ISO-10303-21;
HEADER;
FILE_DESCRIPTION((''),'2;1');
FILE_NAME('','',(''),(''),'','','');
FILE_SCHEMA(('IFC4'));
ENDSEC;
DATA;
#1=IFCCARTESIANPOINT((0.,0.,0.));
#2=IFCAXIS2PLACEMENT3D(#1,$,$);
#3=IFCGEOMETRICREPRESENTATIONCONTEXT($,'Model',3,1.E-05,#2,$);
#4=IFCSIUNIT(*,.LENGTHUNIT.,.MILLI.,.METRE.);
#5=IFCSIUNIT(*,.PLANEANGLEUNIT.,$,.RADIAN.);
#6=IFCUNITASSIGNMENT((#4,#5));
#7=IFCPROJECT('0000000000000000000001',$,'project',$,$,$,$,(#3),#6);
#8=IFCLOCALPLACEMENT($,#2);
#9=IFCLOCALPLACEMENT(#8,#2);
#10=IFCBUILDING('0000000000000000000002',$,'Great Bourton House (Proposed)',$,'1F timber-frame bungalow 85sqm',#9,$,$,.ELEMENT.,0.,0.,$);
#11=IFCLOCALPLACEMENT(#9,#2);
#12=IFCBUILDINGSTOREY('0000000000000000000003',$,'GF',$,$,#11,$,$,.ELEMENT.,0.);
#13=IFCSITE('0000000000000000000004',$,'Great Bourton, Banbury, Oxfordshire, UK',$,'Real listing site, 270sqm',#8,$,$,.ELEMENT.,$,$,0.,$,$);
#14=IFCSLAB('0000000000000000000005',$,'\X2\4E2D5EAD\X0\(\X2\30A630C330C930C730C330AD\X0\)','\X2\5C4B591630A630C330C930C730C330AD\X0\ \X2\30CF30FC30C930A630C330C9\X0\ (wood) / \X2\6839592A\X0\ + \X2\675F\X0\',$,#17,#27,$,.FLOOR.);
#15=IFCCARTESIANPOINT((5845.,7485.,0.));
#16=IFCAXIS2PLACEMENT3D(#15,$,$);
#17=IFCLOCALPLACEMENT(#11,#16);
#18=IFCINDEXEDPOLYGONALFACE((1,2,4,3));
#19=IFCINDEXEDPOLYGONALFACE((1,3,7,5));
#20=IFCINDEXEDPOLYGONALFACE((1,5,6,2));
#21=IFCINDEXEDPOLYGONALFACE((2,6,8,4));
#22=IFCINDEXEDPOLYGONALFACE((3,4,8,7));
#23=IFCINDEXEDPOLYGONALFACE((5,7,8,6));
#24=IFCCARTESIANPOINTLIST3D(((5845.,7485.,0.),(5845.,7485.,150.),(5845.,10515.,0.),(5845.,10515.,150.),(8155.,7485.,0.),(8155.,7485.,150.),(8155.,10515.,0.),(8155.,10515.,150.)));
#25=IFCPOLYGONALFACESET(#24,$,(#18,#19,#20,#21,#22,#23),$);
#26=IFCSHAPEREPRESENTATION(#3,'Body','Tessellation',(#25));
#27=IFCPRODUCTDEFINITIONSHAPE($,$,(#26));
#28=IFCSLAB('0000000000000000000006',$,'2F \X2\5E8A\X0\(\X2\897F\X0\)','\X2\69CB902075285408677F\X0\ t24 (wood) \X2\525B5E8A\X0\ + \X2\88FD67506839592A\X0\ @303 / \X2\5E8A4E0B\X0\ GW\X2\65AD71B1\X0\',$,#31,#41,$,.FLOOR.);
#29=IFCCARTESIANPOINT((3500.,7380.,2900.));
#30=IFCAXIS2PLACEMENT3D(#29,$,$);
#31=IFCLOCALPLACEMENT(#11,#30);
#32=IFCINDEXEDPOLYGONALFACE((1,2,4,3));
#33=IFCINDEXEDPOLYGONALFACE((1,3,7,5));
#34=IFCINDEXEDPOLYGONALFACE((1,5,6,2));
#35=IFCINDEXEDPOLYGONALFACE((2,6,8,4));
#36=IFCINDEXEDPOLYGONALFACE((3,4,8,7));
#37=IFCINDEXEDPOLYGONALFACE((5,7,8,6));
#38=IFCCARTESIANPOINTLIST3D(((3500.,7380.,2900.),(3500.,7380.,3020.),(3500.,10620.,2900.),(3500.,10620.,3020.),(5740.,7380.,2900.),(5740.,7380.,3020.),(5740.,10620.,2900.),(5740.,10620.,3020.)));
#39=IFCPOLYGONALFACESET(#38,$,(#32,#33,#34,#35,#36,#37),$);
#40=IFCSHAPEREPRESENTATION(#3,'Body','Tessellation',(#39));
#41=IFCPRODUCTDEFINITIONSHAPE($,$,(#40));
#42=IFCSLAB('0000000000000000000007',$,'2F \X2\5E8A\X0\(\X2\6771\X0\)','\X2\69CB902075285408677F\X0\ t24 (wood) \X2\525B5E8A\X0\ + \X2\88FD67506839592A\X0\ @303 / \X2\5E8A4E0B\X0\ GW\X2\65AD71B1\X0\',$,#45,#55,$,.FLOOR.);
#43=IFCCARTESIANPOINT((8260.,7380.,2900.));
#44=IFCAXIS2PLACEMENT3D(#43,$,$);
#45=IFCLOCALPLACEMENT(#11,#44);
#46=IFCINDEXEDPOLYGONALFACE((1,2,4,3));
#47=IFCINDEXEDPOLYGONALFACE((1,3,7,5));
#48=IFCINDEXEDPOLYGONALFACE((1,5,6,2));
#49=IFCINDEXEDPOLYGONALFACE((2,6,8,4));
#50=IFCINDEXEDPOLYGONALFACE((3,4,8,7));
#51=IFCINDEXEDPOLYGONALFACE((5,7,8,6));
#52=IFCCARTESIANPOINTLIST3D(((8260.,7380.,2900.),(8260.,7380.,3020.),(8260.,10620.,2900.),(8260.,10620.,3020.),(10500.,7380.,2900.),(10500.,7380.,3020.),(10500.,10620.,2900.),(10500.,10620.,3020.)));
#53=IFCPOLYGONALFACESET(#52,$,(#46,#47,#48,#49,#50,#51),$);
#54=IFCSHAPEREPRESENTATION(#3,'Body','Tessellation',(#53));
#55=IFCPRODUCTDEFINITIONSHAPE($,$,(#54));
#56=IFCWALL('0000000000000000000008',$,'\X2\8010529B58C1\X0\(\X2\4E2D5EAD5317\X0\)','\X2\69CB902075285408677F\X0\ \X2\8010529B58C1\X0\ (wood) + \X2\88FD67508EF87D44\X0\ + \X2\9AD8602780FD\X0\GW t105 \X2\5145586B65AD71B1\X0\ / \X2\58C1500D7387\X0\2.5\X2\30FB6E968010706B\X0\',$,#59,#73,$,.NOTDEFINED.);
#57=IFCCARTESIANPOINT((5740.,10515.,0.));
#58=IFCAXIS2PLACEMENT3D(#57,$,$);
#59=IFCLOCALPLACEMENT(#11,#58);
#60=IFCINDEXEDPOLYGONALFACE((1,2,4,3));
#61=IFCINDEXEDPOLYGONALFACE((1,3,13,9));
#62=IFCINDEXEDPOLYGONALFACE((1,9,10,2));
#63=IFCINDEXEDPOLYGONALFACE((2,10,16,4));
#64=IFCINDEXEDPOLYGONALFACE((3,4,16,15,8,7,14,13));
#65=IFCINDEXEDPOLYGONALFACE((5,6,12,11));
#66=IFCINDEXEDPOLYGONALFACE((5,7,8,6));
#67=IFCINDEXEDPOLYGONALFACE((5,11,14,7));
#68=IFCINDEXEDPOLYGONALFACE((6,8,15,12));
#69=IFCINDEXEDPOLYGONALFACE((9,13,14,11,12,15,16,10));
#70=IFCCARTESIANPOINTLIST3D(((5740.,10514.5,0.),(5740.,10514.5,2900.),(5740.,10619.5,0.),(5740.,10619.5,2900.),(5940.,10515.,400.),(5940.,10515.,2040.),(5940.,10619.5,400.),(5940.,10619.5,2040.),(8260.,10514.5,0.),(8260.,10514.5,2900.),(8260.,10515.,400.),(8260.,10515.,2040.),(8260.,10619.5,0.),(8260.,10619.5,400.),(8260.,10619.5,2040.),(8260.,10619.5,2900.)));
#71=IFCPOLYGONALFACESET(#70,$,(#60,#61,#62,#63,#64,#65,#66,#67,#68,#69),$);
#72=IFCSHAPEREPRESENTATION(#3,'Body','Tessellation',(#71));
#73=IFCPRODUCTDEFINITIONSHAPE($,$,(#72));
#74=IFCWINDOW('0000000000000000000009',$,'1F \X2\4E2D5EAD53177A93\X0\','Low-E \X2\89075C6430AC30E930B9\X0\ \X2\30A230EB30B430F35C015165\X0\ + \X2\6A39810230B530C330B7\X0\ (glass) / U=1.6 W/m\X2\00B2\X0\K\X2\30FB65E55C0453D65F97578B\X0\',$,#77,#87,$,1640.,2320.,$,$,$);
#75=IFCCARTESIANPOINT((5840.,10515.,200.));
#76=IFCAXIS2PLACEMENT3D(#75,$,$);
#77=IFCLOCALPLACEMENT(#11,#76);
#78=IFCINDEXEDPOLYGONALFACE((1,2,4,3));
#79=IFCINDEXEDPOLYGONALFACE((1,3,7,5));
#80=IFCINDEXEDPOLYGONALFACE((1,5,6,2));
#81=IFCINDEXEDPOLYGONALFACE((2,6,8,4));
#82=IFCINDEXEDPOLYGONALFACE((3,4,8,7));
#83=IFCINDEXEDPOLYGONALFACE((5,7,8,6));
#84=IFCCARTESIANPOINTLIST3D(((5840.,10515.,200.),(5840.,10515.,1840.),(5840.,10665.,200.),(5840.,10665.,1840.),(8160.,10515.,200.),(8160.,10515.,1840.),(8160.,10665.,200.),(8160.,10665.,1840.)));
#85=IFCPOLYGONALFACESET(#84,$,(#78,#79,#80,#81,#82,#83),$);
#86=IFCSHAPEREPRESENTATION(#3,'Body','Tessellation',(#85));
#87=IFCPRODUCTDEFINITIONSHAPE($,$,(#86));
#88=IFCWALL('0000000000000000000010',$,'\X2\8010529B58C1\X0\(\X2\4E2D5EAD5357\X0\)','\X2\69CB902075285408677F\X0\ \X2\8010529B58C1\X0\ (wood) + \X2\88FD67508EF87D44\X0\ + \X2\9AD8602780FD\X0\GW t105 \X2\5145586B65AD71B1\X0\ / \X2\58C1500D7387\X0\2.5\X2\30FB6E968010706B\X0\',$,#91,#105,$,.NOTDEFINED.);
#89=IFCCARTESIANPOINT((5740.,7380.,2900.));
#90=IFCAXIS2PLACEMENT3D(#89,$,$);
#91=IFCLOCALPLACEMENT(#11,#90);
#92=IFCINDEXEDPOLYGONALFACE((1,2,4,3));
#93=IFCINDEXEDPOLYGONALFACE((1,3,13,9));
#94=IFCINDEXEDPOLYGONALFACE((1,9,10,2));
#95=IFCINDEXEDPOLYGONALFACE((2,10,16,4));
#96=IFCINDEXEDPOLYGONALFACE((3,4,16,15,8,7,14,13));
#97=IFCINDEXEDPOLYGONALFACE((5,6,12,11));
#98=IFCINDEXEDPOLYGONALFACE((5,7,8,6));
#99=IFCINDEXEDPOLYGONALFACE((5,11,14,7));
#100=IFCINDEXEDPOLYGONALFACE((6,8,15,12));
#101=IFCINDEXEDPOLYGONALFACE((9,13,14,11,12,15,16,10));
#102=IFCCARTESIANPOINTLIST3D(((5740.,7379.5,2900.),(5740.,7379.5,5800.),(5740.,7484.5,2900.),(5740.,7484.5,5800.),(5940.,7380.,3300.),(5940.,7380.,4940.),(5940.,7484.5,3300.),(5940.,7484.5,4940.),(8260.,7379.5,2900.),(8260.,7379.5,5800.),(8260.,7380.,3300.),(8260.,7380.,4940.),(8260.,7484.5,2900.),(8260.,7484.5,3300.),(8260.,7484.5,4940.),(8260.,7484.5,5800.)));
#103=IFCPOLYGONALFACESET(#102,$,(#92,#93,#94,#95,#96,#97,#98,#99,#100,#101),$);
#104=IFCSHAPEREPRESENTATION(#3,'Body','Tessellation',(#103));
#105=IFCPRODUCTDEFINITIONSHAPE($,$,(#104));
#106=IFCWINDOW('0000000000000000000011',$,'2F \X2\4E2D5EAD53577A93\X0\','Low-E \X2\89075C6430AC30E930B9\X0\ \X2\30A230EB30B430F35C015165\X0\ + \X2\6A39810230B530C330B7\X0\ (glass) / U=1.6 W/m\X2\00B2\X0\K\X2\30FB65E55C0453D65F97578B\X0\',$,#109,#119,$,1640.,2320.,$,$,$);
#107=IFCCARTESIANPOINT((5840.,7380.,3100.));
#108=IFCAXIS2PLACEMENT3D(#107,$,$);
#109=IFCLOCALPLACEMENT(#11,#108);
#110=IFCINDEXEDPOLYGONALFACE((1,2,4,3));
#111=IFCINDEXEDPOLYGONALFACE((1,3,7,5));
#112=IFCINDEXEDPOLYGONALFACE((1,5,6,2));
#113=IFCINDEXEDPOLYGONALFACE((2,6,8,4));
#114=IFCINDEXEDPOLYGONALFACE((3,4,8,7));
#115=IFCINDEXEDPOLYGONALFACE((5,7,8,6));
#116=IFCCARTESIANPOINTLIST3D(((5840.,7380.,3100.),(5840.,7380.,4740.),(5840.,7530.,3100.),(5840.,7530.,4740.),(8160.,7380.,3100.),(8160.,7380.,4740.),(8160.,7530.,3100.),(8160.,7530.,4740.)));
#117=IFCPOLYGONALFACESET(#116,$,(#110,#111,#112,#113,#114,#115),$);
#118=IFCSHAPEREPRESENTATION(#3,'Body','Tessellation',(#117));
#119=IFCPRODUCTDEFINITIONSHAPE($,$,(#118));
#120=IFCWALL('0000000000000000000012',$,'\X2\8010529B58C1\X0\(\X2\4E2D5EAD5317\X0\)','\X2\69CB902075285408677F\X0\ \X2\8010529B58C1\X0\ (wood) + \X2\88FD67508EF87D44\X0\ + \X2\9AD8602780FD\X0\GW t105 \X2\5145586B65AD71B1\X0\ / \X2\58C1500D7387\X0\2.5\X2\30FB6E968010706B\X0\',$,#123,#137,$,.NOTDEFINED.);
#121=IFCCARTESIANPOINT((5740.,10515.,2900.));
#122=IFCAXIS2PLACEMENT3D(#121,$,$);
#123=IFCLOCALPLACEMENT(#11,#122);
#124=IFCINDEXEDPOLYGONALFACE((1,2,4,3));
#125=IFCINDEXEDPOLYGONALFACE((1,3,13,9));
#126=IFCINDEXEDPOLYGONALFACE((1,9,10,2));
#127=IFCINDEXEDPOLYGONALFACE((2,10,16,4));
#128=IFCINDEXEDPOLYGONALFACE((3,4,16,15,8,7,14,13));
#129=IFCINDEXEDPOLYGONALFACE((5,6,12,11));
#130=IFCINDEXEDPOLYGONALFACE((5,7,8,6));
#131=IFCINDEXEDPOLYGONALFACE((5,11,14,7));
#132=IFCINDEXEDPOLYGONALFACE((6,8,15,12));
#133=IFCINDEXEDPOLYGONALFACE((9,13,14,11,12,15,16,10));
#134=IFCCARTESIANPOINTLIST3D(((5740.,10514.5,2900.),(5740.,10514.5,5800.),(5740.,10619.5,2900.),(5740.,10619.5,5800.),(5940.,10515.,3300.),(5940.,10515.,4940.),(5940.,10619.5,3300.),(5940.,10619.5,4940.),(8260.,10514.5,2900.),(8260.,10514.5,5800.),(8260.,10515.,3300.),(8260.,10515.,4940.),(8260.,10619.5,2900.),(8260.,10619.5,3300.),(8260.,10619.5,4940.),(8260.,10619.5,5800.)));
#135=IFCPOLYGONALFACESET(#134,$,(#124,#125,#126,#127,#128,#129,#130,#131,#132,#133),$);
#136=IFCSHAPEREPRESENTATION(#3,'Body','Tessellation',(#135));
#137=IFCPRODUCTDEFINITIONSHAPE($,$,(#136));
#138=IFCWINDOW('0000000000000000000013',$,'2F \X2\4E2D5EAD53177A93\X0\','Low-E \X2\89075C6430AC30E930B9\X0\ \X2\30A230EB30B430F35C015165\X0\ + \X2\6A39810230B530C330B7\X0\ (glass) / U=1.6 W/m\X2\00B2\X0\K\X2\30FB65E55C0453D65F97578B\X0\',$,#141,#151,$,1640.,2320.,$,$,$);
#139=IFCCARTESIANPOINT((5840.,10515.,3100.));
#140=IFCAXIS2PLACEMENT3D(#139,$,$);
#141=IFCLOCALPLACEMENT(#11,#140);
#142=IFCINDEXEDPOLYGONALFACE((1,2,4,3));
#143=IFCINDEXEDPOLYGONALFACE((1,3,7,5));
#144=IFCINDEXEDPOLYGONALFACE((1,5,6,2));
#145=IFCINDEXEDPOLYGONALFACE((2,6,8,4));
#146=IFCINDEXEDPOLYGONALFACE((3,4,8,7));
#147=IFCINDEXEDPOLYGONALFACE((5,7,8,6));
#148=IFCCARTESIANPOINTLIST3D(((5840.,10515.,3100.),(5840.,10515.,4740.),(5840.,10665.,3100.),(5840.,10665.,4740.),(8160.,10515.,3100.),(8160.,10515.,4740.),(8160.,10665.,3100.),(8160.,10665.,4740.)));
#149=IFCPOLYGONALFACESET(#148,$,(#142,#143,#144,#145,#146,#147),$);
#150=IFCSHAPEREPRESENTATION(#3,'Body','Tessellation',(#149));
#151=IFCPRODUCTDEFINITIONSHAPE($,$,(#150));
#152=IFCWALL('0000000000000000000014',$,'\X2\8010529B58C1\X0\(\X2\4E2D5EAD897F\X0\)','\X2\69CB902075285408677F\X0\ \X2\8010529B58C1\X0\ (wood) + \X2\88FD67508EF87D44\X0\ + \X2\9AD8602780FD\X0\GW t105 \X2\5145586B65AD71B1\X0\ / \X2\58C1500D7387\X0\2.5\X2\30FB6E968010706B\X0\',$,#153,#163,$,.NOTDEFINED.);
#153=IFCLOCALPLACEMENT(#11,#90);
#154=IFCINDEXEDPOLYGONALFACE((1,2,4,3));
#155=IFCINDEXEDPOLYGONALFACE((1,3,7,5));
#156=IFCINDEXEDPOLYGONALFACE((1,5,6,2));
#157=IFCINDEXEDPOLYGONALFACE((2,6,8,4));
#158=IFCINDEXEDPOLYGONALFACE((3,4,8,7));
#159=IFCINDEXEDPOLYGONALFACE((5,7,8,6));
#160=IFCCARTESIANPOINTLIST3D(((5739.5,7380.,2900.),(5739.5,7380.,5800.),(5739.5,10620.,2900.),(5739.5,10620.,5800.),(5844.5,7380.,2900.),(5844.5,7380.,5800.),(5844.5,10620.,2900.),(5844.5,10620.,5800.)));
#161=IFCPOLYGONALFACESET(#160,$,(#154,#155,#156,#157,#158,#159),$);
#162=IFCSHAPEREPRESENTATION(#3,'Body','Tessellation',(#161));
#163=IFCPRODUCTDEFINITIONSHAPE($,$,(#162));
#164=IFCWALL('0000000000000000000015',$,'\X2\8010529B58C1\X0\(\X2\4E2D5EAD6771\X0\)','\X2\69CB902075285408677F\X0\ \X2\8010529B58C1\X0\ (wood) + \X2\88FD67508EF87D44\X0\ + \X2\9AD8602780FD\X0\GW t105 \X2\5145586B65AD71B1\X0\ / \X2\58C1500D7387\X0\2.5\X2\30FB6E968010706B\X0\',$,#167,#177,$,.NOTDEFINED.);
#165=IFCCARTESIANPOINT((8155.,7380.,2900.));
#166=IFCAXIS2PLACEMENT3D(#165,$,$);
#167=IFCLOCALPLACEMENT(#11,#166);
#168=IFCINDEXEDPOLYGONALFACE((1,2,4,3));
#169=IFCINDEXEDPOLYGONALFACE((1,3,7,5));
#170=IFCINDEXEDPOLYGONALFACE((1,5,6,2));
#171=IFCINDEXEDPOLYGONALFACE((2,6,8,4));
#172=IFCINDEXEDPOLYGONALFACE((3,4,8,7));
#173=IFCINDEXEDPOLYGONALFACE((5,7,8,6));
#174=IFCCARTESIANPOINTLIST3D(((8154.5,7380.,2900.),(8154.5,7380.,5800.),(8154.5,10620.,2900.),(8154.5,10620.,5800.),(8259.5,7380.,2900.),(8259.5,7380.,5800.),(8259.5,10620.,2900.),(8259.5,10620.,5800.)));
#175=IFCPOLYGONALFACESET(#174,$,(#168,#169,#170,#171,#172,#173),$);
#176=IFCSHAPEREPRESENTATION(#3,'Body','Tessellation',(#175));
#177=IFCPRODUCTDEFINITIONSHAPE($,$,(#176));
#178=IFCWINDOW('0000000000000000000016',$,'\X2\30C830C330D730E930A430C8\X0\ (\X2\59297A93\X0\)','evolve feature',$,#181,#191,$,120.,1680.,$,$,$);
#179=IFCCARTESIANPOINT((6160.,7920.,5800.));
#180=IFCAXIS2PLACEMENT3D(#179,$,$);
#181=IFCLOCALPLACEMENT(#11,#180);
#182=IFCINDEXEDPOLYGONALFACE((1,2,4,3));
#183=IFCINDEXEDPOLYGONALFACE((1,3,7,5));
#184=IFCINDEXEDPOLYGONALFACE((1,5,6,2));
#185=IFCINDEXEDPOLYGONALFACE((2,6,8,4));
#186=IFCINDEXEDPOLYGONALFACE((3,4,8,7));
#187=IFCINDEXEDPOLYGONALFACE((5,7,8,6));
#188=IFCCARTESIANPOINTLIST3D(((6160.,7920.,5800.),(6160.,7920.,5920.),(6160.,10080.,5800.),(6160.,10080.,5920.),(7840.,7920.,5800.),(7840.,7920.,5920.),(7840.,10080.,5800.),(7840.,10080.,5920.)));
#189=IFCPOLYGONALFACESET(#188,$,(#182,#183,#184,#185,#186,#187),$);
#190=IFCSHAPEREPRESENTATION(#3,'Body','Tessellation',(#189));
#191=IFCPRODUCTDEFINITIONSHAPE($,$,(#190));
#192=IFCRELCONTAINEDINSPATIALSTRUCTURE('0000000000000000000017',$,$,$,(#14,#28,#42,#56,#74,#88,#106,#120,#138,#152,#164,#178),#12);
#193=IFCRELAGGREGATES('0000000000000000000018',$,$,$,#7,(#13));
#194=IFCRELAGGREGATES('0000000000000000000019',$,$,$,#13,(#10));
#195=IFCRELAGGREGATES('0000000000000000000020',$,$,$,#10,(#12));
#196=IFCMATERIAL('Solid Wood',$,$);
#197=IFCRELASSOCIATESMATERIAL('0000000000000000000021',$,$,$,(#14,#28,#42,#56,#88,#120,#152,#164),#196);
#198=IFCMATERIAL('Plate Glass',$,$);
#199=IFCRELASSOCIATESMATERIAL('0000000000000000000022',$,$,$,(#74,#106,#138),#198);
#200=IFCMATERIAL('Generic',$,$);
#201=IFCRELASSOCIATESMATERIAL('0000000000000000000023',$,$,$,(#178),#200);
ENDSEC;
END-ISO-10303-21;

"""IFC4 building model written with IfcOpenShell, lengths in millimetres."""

from ifc_helpers import new_model, si_unit, frame, frame_2d, origin, place, context, project, spatial, rectangle, extrude, material, element, fill, save


model = new_model("IFC4")

# Units and contexts
model_context = context("Model", 3, precision=1e-05, world=origin())
ifc_project = project(units=[si_unit("LENGTHUNIT", "METRE", prefix="MILLI"), si_unit("PLANEANGLEUNIT", "RADIAN")], contexts=[model_context])

# Site, building, storey
site_placement = place(None, origin())
site = spatial("IfcSite", under=ifc_project, at=site_placement, Name="Great Bourton, Banbury, Oxfordshire, UK", ObjectType="Real listing site, 270sqm", CompositionType="ELEMENT", RefElevation=0.0)
building_placement = place(site_placement, origin())
building = spatial("IfcBuilding", under=site, at=building_placement, Name="Great Bourton House (Proposed)", ObjectType="1F timber-frame bungalow 85sqm", CompositionType="ELEMENT", ElevationOfRefHeight=0.0, ElevationOfTerrain=0.0)
storey_placement = place(building_placement, origin())
storey = spatial("IfcBuildingStorey", under=building, at=storey_placement, Name="GF", CompositionType="ELEMENT", Elevation=0.0)

# Slabs
ifc_material_1 = material(Name="Solid Wood")
slab_1_placement = place(storey_placement, frame((5845.0, 7485.0, 0.0)))
element("IfcSlab", 1, at=slab_1_placement, inside=storey, material=ifc_material_1, Name="中庭(ウッドデッキ)", Description="屋外ウッドデッキ ハードウッド (wood) / 根太 + 束", PredefinedType="FLOOR", context=model_context, shape_type="SweptSolid", body=[
    extrude(rectangle(XDim=2310.0, YDim=3030.0, at=frame_2d((1155.0, 1515.0))), frame((5845.0, 7485.0, 0.0)), (0.0, 0.0, 1.0), 150.0),
])
slab_2_placement = place(storey_placement, frame((3500.0, 7380.0, 2900.0)))
element("IfcSlab", 2, at=slab_2_placement, inside=storey, material=ifc_material_1, Name="2F 床(西)", Description="構造用合板 t24 (wood) 剛床 + 製材根太 @303 / 床下 GW断熱", PredefinedType="FLOOR", context=model_context, shape_type="SweptSolid", body=[
    extrude(rectangle(XDim=2240.0, YDim=3240.0, at=frame_2d((1120.0, 1620.0))), frame((3500.0, 7380.0, 2900.0)), (0.0, 0.0, 1.0), 120.0),
])
slab_3_placement = place(storey_placement, frame((8260.0, 7380.0, 2900.0)))
element("IfcSlab", 3, at=slab_3_placement, inside=storey, material=ifc_material_1, Name="2F 床(東)", Description="構造用合板 t24 (wood) 剛床 + 製材根太 @303 / 床下 GW断熱", PredefinedType="FLOOR", context=model_context, shape_type="SweptSolid", body=[
    extrude(rectangle(XDim=2240.0, YDim=3240.0, at=frame_2d((1120.0, 1620.0))), frame((8260.0, 7380.0, 2900.0)), (0.0, 0.0, 1.0), 120.0),
])

# Walls, openings, windows
wall_1_placement = place(storey_placement, frame((5740.0, 10515.0, 0.0)))
wall_1 = element("IfcWall", 4, at=wall_1_placement, inside=storey, material=ifc_material_1, Name="耐力壁(中庭北)", Description="構造用合板 耐力壁 (wood) + 製材軸組 + 高性能GW t105 充填断熱 / 壁倍率2.5・準耐火", PredefinedType="NOTDEFINED", context=model_context, shape_type="SweptSolid", body=[
    extrude(rectangle(XDim=2520.0, YDim=105.0, at=frame_2d((1260.0, 52.0))), frame((5740.0, 10515.0, 0.0)), (0.0, 0.0, 1.0), 2900.0),
])
opening_1_placement = place(storey_placement, frame((5840.0, 10515.0, 200.0)))
opening_1 = element("IfcOpeningElement", 5, at=opening_1_placement, cuts=wall_1, PredefinedType="NOTDEFINED", context=model_context, shape_type="SweptSolid", body=[
    extrude(rectangle(XDim=2320.0, YDim=150.0, at=frame_2d((1160.0, 75.0))), frame((5840.0, 10515.0, 200.0)), (0.0, 0.0, 1.0), 1640.0),
])
ifc_material_2 = material(Name="Plate Glass")
window_1_placement = place(storey_placement, frame((5840.0, 10515.0, 200.0)))
window_1 = element("IfcWindow", 6, at=window_1_placement, inside=storey, material=ifc_material_2, Name="1F 中庭北窓", Description="Low-E 複層ガラス アルゴン封入 + 樹脂サッシ (glass) / U=1.6 W/m²K・日射取得型", OverallHeight=1640.0, OverallWidth=2320.0, context=model_context, shape_type="SweptSolid", body=[
    extrude(rectangle(XDim=2320.0, YDim=150.0, at=frame_2d((1160.0, 75.0))), frame((5840.0, 10515.0, 200.0)), (0.0, 0.0, 1.0), 1640.0),
])
fill(opening_1, window_1)
wall_2_placement = place(storey_placement, frame((5740.0, 7380.0, 2900.0)))
wall_2 = element("IfcWall", 7, at=wall_2_placement, inside=storey, material=ifc_material_1, Name="耐力壁(中庭南)", Description="構造用合板 耐力壁 (wood) + 製材軸組 + 高性能GW t105 充填断熱 / 壁倍率2.5・準耐火", PredefinedType="NOTDEFINED", context=model_context, shape_type="SweptSolid", body=[
    extrude(rectangle(XDim=2520.0, YDim=105.0, at=frame_2d((1260.0, 52.0))), frame((5740.0, 7380.0, 2900.0)), (0.0, 0.0, 1.0), 2900.0),
])
opening_2_placement = place(storey_placement, frame((5840.0, 7380.0, 3100.0)))
opening_2 = element("IfcOpeningElement", 8, at=opening_2_placement, cuts=wall_2, PredefinedType="NOTDEFINED", context=model_context, shape_type="SweptSolid", body=[
    extrude(rectangle(XDim=2320.0, YDim=150.0, at=frame_2d((1160.0, 75.0))), frame((5840.0, 7380.0, 3100.0)), (0.0, 0.0, 1.0), 1640.0),
])
window_2_placement = place(storey_placement, frame((5840.0, 7380.0, 3100.0)))
window_2 = element("IfcWindow", 9, at=window_2_placement, inside=storey, material=ifc_material_2, Name="2F 中庭南窓", Description="Low-E 複層ガラス アルゴン封入 + 樹脂サッシ (glass) / U=1.6 W/m²K・日射取得型", OverallHeight=1640.0, OverallWidth=2320.0, context=model_context, shape_type="SweptSolid", body=[
    extrude(rectangle(XDim=2320.0, YDim=150.0, at=frame_2d((1160.0, 75.0))), frame((5840.0, 7380.0, 3100.0)), (0.0, 0.0, 1.0), 1640.0),
])
fill(opening_2, window_2)
wall_3_placement = place(storey_placement, frame((5740.0, 10515.0, 2900.0)))
wall_3 = element("IfcWall", 10, at=wall_3_placement, inside=storey, material=ifc_material_1, Name="耐力壁(中庭北)", Description="構造用合板 耐力壁 (wood) + 製材軸組 + 高性能GW t105 充填断熱 / 壁倍率2.5・準耐火", PredefinedType="NOTDEFINED", context=model_context, shape_type="SweptSolid", body=[
    extrude(rectangle(XDim=2520.0, YDim=105.0, at=frame_2d((1260.0, 52.0))), frame((5740.0, 10515.0, 2900.0)), (0.0, 0.0, 1.0), 2900.0),
])
opening_3_placement = place(storey_placement, frame((5840.0, 10515.0, 3100.0)))
opening_3 = element("IfcOpeningElement", 11, at=opening_3_placement, cuts=wall_3, PredefinedType="NOTDEFINED", context=model_context, shape_type="SweptSolid", body=[
    extrude(rectangle(XDim=2320.0, YDim=150.0, at=frame_2d((1160.0, 75.0))), frame((5840.0, 10515.0, 3100.0)), (0.0, 0.0, 1.0), 1640.0),
])
window_3_placement = place(storey_placement, frame((5840.0, 10515.0, 3100.0)))
window_3 = element("IfcWindow", 12, at=window_3_placement, inside=storey, material=ifc_material_2, Name="2F 中庭北窓", Description="Low-E 複層ガラス アルゴン封入 + 樹脂サッシ (glass) / U=1.6 W/m²K・日射取得型", OverallHeight=1640.0, OverallWidth=2320.0, context=model_context, shape_type="SweptSolid", body=[
    extrude(rectangle(XDim=2320.0, YDim=150.0, at=frame_2d((1160.0, 75.0))), frame((5840.0, 10515.0, 3100.0)), (0.0, 0.0, 1.0), 1640.0),
])
fill(opening_3, window_3)

# Walls
wall_4_placement = place(storey_placement, frame((5740.0, 7380.0, 2900.0)))
element("IfcWall", 13, at=wall_4_placement, inside=storey, material=ifc_material_1, Name="耐力壁(中庭西)", Description="構造用合板 耐力壁 (wood) + 製材軸組 + 高性能GW t105 充填断熱 / 壁倍率2.5・準耐火", PredefinedType="NOTDEFINED", context=model_context, shape_type="SweptSolid", body=[
    extrude(rectangle(XDim=105.0, YDim=3240.0, at=frame_2d((52.0, 1620.0))), frame((5740.0, 7380.0, 2900.0)), (0.0, 0.0, 1.0), 2900.0),
])
wall_5_placement = place(storey_placement, frame((8155.0, 7380.0, 2900.0)))
element("IfcWall", 14, at=wall_5_placement, inside=storey, material=ifc_material_1, Name="耐力壁(中庭東)", Description="構造用合板 耐力壁 (wood) + 製材軸組 + 高性能GW t105 充填断熱 / 壁倍率2.5・準耐火", PredefinedType="NOTDEFINED", context=model_context, shape_type="SweptSolid", body=[
    extrude(rectangle(XDim=105.0, YDim=3240.0, at=frame_2d((52.0, 1620.0))), frame((8155.0, 7380.0, 2900.0)), (0.0, 0.0, 1.0), 2900.0),
])

# Window
ifc_material_3 = material(Name="Generic")
window_4_placement = place(storey_placement, frame((6160.0, 7920.0, 5800.0)))
element("IfcWindow", 15, at=window_4_placement, inside=storey, material=ifc_material_3, Name="トップライト (天窓)", Description="evolve feature", OverallHeight=120.0, OverallWidth=1680.0, context=model_context, shape_type="SweptSolid", body=[
    extrude(rectangle(XDim=1680.0, YDim=2160.0, at=frame_2d((840.0, 1080.0))), frame((6160.0, 7920.0, 5800.0)), (0.0, 0.0, 1.0), 120.0),
])

save(model, "model.ifc")
